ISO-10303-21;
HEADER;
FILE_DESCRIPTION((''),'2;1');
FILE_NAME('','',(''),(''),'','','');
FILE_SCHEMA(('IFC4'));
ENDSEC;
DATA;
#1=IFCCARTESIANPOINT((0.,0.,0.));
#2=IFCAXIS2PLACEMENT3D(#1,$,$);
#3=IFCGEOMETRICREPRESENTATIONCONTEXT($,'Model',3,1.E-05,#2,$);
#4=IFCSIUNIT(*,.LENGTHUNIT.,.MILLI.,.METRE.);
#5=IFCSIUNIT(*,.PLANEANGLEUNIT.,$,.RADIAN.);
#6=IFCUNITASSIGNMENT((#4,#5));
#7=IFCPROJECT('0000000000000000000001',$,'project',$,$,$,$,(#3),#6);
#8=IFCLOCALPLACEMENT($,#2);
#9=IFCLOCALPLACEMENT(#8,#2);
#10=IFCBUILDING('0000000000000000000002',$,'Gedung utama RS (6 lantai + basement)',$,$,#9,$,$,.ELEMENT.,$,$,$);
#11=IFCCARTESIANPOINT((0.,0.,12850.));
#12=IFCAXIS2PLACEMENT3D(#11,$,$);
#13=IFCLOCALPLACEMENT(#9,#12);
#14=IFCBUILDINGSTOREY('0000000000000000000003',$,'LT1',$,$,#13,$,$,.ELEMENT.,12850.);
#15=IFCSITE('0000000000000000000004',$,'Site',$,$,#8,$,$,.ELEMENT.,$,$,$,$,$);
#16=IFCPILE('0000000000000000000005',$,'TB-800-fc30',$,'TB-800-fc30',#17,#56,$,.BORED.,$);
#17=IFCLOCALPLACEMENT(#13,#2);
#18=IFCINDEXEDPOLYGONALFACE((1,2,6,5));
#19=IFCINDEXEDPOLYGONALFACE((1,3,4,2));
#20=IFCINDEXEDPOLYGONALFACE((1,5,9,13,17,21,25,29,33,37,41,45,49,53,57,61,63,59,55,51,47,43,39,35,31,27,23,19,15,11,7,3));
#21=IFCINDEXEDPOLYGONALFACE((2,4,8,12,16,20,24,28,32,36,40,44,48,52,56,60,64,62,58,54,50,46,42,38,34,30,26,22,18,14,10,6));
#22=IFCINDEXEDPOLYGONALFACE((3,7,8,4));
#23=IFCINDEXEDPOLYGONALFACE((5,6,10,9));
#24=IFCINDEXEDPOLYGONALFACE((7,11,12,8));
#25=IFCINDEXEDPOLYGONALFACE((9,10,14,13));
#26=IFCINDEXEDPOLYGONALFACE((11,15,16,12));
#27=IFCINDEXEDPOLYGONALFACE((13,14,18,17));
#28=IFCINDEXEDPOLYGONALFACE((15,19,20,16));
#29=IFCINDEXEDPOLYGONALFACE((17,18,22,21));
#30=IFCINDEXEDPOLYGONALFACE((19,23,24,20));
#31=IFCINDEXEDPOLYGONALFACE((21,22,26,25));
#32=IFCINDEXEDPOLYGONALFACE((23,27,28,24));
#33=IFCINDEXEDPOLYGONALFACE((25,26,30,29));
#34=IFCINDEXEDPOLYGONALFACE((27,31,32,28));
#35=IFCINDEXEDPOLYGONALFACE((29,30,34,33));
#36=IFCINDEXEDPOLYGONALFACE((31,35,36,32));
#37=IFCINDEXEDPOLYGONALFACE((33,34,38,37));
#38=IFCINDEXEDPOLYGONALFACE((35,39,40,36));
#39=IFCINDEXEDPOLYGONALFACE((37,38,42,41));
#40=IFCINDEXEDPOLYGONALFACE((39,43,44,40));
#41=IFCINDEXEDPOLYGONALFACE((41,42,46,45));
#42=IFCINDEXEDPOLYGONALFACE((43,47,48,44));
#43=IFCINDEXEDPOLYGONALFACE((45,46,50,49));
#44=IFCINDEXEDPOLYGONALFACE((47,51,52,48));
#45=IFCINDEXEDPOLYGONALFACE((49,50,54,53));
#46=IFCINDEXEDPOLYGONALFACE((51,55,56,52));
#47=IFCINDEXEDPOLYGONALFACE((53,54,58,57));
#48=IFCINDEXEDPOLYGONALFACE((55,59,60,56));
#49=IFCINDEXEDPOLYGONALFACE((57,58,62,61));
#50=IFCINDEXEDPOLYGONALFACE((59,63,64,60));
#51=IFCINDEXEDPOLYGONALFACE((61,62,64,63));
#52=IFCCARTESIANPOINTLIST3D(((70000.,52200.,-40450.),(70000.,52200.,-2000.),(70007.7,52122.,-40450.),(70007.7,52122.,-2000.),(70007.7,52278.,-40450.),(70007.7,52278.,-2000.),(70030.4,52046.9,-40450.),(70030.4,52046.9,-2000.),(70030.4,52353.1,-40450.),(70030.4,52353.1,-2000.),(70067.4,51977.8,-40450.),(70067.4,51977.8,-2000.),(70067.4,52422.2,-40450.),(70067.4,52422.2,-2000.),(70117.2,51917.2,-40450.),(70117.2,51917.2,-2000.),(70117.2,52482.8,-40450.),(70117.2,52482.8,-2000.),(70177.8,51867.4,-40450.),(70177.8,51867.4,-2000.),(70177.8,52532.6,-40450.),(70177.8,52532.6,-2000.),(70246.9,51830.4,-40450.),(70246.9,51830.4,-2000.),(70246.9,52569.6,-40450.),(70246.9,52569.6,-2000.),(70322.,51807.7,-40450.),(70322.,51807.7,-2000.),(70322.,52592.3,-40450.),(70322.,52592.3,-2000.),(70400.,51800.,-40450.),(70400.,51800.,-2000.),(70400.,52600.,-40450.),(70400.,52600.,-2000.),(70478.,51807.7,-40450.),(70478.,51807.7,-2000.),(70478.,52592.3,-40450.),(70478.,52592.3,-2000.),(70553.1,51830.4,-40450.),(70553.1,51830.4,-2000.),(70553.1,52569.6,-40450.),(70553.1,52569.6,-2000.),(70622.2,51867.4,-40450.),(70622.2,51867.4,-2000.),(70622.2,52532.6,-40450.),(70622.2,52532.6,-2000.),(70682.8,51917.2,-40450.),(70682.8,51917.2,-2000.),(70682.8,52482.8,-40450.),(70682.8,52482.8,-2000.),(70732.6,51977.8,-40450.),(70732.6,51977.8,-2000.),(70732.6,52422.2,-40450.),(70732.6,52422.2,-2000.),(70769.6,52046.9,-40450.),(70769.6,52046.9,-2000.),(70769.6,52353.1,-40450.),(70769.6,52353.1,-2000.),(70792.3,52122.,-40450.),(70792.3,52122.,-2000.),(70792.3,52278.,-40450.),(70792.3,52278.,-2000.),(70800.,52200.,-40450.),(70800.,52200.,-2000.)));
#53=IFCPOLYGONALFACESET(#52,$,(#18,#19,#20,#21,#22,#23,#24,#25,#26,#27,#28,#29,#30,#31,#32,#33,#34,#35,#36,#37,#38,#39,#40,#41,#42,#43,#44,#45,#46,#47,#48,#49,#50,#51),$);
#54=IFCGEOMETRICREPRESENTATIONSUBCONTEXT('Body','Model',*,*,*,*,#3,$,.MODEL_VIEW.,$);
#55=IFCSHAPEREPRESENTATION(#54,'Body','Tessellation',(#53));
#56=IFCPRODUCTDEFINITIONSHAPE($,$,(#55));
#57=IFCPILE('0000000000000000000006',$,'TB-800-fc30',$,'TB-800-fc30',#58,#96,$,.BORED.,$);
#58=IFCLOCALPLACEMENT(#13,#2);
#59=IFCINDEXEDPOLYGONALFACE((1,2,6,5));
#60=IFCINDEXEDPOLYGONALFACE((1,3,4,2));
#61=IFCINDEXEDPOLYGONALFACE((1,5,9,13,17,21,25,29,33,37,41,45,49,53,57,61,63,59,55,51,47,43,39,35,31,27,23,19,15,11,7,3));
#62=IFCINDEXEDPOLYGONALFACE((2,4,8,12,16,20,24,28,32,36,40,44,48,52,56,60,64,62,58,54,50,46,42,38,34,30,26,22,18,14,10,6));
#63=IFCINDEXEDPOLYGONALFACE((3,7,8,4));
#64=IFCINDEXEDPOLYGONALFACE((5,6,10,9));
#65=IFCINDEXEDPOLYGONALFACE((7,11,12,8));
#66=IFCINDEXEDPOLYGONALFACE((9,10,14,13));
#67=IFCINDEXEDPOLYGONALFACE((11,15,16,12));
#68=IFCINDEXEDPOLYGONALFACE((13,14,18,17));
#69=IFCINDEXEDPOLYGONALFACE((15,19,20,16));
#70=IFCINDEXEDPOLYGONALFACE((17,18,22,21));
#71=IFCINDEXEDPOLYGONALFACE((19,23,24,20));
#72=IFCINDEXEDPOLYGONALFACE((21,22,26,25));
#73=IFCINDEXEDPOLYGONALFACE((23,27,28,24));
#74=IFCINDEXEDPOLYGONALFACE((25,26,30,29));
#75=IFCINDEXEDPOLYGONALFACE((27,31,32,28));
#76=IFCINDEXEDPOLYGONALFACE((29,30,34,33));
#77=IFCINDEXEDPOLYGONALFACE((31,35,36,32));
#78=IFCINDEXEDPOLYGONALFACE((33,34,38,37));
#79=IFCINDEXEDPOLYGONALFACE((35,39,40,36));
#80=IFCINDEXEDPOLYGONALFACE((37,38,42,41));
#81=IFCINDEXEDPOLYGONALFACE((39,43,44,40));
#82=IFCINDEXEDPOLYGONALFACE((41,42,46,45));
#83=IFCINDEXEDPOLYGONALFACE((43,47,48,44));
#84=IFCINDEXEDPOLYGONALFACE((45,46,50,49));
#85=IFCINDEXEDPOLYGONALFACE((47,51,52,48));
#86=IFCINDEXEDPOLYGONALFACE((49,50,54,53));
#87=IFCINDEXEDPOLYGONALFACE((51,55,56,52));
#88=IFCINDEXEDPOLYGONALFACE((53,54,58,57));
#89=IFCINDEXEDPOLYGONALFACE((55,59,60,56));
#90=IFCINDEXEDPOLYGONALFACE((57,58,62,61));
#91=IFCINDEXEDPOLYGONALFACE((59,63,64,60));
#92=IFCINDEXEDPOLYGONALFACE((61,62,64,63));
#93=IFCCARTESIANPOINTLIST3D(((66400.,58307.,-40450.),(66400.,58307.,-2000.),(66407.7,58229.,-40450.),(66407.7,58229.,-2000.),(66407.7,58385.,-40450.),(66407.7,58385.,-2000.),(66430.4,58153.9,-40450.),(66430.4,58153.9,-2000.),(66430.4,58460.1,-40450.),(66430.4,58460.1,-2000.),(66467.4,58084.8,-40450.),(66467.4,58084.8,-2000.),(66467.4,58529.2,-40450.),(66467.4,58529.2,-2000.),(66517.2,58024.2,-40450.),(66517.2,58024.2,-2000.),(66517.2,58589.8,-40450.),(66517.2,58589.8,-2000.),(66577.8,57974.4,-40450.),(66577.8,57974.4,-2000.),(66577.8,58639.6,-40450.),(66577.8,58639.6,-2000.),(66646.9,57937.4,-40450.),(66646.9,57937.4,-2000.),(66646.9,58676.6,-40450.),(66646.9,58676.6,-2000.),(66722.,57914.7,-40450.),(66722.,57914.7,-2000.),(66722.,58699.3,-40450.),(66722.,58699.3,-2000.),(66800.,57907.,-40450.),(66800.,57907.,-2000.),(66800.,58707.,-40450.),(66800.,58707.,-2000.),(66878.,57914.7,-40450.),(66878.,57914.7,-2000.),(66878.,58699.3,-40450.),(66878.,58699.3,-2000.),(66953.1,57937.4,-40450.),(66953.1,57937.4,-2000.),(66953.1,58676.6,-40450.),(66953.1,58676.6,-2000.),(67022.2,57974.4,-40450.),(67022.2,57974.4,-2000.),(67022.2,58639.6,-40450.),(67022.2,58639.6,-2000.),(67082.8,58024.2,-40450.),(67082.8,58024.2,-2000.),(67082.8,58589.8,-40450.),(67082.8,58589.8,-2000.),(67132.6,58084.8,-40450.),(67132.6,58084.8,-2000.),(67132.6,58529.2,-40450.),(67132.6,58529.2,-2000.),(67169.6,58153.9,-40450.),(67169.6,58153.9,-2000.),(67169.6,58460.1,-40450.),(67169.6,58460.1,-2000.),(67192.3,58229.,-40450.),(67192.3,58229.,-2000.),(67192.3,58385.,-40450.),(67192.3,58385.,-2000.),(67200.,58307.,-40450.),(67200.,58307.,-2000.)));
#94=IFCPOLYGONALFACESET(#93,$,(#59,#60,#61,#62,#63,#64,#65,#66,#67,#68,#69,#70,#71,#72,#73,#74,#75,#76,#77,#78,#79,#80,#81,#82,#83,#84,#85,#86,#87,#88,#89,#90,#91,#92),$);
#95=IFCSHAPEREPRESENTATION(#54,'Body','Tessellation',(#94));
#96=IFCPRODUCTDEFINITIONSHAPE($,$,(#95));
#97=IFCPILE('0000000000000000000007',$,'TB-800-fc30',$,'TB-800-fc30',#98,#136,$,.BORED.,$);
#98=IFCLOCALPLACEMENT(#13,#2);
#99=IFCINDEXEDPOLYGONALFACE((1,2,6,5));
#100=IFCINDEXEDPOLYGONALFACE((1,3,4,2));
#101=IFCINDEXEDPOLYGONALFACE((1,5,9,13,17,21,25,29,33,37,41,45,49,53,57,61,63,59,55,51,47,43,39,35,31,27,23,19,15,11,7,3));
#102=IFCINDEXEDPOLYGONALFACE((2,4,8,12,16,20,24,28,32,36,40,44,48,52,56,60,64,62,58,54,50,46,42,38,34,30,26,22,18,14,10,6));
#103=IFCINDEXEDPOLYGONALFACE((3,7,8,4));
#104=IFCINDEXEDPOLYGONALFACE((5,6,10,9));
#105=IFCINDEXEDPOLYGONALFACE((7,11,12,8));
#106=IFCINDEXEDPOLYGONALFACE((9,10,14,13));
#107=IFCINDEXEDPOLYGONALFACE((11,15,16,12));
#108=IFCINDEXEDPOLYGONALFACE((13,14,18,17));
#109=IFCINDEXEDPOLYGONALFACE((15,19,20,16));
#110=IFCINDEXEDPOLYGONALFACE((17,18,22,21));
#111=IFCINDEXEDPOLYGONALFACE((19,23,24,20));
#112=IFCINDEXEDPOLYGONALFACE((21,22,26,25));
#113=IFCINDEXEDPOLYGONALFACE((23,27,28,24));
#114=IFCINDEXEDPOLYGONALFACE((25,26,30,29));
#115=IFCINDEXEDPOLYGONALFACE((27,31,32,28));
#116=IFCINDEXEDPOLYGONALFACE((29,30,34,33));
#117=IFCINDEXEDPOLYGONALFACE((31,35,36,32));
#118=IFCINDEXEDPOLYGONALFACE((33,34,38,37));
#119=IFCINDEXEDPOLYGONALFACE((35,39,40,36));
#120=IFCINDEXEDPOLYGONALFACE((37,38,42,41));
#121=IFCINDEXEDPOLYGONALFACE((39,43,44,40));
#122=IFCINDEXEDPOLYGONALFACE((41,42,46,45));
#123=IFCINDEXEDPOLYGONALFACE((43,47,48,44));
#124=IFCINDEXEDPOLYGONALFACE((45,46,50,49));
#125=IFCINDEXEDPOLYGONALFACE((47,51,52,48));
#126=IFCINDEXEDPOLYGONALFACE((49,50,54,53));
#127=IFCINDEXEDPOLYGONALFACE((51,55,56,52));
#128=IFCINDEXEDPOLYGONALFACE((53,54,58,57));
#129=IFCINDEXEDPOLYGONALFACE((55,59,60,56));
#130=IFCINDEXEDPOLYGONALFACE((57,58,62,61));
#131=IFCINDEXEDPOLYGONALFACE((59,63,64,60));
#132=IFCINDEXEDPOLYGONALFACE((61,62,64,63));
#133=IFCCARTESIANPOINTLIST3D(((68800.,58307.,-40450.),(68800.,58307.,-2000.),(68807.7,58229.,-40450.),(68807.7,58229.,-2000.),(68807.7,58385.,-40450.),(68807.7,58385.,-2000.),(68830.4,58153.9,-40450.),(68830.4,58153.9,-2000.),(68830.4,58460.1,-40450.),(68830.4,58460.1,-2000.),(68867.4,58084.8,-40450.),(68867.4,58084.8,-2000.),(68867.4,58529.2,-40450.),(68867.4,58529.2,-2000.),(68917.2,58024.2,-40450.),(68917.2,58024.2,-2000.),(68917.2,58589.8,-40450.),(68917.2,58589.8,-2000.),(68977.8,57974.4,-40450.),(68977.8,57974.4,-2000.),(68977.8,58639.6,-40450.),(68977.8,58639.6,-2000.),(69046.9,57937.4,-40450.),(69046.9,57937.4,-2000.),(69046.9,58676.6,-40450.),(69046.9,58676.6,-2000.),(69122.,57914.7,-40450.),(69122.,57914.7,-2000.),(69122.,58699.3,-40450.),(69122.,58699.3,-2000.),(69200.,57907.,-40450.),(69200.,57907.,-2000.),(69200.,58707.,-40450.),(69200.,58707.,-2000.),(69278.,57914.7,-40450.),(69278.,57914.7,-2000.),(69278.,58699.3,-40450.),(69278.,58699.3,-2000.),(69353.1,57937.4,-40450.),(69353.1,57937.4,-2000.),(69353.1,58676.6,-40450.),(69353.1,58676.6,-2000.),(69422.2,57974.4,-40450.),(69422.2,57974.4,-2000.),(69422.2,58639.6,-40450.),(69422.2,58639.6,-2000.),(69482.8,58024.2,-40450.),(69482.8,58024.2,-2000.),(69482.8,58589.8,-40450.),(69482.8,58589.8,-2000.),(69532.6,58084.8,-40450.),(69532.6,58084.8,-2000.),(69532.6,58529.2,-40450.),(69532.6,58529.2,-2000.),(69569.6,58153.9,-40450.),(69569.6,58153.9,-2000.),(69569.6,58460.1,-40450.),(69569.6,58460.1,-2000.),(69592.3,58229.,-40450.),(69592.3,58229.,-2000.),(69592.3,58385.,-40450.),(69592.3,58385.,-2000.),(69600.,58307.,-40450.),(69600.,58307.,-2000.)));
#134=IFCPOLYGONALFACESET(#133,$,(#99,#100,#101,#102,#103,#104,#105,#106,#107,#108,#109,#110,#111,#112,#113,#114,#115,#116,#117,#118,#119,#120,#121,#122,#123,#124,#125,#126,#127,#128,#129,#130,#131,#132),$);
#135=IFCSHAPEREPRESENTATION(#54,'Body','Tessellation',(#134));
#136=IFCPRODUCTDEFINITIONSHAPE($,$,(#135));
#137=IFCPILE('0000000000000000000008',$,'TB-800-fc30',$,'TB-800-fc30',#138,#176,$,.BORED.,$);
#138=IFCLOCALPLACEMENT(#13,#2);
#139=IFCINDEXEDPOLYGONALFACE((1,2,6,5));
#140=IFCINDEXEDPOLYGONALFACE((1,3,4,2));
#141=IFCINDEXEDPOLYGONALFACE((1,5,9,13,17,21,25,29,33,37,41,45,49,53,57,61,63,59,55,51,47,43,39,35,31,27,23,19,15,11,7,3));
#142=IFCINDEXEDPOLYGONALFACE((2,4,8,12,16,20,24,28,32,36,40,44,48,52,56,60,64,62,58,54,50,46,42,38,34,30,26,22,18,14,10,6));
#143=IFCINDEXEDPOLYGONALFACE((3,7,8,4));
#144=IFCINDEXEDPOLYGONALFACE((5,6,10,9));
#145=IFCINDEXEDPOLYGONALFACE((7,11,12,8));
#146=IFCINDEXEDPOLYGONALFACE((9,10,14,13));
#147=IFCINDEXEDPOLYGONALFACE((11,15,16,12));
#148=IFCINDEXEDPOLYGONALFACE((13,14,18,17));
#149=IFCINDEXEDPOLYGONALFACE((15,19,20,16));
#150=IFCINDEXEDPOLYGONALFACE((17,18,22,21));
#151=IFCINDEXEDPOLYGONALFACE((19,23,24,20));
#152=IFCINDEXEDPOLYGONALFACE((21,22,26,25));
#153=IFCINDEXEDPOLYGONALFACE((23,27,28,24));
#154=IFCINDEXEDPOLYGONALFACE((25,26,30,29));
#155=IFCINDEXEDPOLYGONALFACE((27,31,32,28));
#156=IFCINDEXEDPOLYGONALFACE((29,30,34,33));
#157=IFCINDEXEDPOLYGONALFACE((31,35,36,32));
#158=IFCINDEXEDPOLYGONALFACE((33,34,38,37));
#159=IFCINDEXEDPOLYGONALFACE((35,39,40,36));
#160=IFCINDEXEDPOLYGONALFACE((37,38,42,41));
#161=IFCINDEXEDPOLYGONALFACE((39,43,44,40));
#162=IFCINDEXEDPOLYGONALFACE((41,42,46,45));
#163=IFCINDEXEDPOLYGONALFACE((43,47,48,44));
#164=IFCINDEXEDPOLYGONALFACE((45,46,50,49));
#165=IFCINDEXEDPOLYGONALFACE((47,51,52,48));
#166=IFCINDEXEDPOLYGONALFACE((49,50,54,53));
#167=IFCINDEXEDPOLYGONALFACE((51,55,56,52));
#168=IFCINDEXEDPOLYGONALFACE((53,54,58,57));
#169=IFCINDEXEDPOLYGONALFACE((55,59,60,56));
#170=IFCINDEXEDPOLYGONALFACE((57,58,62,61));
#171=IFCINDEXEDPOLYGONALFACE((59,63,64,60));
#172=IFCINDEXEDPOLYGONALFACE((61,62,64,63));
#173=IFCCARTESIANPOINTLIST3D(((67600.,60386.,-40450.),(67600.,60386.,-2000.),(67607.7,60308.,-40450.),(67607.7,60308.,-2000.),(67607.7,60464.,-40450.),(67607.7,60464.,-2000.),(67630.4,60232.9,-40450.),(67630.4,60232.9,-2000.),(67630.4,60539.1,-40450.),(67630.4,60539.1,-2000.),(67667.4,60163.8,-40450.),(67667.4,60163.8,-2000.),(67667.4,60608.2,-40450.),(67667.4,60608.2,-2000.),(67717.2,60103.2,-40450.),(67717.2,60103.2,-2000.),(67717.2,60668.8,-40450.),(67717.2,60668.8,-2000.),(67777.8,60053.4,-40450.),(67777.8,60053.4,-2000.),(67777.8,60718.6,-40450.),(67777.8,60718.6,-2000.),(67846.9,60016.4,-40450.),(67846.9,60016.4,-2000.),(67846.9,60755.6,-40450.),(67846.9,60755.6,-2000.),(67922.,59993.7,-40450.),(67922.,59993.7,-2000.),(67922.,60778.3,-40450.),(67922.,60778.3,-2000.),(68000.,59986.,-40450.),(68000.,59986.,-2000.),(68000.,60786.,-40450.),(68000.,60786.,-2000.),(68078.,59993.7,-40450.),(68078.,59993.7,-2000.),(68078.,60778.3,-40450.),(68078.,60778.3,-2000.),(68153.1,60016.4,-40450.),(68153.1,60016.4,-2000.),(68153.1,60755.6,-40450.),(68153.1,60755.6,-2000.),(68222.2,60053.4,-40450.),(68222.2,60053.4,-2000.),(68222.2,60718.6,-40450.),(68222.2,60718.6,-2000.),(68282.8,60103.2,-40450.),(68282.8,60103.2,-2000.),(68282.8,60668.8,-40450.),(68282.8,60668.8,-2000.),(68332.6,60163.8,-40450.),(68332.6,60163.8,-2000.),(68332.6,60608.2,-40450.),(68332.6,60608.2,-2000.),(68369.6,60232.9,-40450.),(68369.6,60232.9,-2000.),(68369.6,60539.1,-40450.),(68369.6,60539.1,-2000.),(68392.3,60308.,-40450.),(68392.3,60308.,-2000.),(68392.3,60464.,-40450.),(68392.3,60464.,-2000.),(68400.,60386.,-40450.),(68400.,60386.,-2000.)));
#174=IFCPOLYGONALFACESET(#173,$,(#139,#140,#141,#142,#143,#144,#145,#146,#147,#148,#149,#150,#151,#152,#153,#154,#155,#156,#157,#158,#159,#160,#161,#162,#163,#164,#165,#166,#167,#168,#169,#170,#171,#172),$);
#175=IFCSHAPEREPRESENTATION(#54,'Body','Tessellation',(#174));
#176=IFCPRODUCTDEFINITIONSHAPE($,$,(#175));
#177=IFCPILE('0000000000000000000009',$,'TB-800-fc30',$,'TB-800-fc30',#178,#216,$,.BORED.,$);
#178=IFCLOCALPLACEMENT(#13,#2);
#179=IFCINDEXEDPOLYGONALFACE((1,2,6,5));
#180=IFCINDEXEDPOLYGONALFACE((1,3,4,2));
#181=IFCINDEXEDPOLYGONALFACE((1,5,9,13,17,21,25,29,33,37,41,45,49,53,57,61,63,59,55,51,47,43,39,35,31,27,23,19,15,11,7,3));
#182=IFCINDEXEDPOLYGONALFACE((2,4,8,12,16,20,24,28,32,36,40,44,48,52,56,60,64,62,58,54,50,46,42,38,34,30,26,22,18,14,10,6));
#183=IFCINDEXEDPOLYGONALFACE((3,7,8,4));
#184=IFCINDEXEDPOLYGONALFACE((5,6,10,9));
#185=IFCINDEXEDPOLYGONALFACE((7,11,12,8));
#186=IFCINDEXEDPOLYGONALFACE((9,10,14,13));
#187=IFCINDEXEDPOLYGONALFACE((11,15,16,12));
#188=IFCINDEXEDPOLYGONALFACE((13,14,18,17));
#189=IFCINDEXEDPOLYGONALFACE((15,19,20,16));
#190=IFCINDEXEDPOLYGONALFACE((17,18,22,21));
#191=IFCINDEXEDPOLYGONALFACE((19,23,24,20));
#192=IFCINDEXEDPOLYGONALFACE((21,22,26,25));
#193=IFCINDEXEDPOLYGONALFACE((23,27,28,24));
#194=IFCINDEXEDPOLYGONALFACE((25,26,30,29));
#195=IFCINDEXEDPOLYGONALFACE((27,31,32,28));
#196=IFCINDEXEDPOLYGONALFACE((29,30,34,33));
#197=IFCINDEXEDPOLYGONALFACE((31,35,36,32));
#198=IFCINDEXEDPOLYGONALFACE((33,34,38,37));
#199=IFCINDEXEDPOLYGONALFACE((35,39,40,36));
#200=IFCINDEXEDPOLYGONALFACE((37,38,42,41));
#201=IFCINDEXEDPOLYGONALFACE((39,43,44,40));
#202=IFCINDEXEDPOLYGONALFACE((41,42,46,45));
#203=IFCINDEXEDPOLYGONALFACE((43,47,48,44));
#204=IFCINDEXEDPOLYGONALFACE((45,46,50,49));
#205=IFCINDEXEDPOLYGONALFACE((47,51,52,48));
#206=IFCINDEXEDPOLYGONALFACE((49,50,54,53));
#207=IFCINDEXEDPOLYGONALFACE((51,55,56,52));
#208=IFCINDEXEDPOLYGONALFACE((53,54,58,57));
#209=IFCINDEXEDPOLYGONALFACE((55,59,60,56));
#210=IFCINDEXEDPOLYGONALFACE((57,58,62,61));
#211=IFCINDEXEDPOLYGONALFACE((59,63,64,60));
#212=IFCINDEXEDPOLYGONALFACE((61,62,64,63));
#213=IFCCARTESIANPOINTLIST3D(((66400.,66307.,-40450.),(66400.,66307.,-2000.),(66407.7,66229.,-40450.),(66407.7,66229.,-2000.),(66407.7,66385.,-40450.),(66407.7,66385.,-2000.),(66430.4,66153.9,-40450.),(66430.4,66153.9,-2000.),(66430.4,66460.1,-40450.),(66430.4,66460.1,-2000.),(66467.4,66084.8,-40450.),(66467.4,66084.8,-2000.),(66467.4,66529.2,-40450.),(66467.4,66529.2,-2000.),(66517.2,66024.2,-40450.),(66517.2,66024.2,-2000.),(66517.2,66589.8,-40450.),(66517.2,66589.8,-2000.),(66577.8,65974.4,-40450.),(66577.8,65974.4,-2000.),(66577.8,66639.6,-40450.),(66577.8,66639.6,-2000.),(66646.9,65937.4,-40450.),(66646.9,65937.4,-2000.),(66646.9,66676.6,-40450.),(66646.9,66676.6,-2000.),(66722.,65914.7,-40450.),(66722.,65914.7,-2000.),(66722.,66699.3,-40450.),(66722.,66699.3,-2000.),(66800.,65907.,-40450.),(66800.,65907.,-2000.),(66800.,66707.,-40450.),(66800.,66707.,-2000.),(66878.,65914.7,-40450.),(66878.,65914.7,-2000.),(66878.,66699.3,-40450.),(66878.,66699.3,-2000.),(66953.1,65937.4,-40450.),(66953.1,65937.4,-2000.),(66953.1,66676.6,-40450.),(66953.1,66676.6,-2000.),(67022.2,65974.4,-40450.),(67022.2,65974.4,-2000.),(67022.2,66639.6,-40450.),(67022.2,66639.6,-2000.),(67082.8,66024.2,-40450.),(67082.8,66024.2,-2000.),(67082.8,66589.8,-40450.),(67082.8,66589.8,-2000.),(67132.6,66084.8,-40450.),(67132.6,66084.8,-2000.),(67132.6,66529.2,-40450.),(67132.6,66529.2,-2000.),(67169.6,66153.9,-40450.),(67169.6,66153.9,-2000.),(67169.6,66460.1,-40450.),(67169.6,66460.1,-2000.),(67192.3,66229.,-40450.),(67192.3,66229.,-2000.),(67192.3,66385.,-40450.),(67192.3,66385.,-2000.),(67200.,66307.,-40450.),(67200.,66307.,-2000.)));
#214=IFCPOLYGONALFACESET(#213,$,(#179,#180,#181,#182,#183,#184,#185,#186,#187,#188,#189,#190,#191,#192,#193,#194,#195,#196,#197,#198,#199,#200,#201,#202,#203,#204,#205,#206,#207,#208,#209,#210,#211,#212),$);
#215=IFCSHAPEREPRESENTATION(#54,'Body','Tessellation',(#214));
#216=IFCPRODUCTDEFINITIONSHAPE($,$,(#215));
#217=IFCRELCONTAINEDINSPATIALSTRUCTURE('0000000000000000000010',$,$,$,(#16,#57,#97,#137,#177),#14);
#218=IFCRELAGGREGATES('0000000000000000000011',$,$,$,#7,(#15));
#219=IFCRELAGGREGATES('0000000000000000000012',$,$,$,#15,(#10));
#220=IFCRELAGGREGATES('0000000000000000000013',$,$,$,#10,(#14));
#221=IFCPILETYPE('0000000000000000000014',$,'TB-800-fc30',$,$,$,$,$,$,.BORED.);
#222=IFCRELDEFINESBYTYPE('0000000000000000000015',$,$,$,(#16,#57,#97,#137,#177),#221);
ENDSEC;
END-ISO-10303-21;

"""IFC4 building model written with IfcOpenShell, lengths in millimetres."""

from ifc_helpers import new_model, si_unit, frame, origin, origin_2d, place, context, subcontext, project, spatial, circle, extrude, material_profile, profile_set, profile_usage, type_object, element, save


model = new_model("IFC4")

# Units and contexts
model_context = context("Model", 3, precision=1e-05, world=origin())
body_context = subcontext(model_context, "Body", "Model", "MODEL_VIEW")
ifc_project = project(units=[si_unit("LENGTHUNIT", "METRE", prefix="MILLI"), si_unit("PLANEANGLEUNIT", "RADIAN")], contexts=[model_context])

# Site, building, storey
site_placement = place(None, origin())
site = spatial("IfcSite", under=ifc_project, at=site_placement, Name="Site", CompositionType="ELEMENT")
building_placement = place(site_placement, origin())
building = spatial("IfcBuilding", under=site, at=building_placement, Name="Gedung utama RS (6 lantai + basement)", CompositionType="ELEMENT")
storey_placement = place(building_placement, frame((0.0, 0.0, 12850.0)))
storey = spatial("IfcBuildingStorey", under=building, at=storey_placement, Name="LT1", CompositionType="ELEMENT", Elevation=12850.0)

# Piles
ifc_material_profile = material_profile(None, circle(Radius=400.0, at=origin_2d()), Name="TB-800-fc30")
ifc_profile_set = profile_set([ifc_material_profile], Name="TB-800-fc30")
ifc_profile_usage = profile_usage(ifc_profile_set, cardinal=5)
pile_type = type_object("IfcPileType", Name="TB-800-fc30", PredefinedType="BORED", material=ifc_profile_set)
for number, where, z_axis, x_axis, name in (
    (1, (70400.0, 52200.0, -40450.0), (0.0, 0.0, 1.0), (1.0, 0.0, 0.0), "TB-800-fc30"),
    (2, (66800.0, 58307.0, -40450.0), (0.0, 0.0, 1.0), (1.0, 0.0, 0.0), "TB-800-fc30"),
    (3, (69200.0, 58307.0, -40450.0), (0.0, 0.0, 1.0), (1.0, 0.0, 0.0), "TB-800-fc30"),
    (4, (68000.0, 60386.0, -40450.0), (0.0, 0.0, 1.0), (1.0, 0.0, 0.0), "TB-800-fc30"),
    (5, (66800.0, 66307.0, -40450.0), (0.0, 0.0, 1.0), (1.0, 0.0, 0.0), "TB-800-fc30"),
):
    element("IfcPile", number, at=place(storey_placement, frame(where, z_axis=z_axis, x_axis=x_axis)), inside=storey, type_object=pile_type, material=ifc_profile_usage, Name=name, ObjectType="TB-800-fc30", PredefinedType="BORED", context=body_context, shape_type="SweptSolid", body=[
        extrude(circle(Radius=400.0, at=origin_2d()), origin(), (0.0, 0.0, 1.0), 38450.0),
    ])

save(model, "model.ifc")
